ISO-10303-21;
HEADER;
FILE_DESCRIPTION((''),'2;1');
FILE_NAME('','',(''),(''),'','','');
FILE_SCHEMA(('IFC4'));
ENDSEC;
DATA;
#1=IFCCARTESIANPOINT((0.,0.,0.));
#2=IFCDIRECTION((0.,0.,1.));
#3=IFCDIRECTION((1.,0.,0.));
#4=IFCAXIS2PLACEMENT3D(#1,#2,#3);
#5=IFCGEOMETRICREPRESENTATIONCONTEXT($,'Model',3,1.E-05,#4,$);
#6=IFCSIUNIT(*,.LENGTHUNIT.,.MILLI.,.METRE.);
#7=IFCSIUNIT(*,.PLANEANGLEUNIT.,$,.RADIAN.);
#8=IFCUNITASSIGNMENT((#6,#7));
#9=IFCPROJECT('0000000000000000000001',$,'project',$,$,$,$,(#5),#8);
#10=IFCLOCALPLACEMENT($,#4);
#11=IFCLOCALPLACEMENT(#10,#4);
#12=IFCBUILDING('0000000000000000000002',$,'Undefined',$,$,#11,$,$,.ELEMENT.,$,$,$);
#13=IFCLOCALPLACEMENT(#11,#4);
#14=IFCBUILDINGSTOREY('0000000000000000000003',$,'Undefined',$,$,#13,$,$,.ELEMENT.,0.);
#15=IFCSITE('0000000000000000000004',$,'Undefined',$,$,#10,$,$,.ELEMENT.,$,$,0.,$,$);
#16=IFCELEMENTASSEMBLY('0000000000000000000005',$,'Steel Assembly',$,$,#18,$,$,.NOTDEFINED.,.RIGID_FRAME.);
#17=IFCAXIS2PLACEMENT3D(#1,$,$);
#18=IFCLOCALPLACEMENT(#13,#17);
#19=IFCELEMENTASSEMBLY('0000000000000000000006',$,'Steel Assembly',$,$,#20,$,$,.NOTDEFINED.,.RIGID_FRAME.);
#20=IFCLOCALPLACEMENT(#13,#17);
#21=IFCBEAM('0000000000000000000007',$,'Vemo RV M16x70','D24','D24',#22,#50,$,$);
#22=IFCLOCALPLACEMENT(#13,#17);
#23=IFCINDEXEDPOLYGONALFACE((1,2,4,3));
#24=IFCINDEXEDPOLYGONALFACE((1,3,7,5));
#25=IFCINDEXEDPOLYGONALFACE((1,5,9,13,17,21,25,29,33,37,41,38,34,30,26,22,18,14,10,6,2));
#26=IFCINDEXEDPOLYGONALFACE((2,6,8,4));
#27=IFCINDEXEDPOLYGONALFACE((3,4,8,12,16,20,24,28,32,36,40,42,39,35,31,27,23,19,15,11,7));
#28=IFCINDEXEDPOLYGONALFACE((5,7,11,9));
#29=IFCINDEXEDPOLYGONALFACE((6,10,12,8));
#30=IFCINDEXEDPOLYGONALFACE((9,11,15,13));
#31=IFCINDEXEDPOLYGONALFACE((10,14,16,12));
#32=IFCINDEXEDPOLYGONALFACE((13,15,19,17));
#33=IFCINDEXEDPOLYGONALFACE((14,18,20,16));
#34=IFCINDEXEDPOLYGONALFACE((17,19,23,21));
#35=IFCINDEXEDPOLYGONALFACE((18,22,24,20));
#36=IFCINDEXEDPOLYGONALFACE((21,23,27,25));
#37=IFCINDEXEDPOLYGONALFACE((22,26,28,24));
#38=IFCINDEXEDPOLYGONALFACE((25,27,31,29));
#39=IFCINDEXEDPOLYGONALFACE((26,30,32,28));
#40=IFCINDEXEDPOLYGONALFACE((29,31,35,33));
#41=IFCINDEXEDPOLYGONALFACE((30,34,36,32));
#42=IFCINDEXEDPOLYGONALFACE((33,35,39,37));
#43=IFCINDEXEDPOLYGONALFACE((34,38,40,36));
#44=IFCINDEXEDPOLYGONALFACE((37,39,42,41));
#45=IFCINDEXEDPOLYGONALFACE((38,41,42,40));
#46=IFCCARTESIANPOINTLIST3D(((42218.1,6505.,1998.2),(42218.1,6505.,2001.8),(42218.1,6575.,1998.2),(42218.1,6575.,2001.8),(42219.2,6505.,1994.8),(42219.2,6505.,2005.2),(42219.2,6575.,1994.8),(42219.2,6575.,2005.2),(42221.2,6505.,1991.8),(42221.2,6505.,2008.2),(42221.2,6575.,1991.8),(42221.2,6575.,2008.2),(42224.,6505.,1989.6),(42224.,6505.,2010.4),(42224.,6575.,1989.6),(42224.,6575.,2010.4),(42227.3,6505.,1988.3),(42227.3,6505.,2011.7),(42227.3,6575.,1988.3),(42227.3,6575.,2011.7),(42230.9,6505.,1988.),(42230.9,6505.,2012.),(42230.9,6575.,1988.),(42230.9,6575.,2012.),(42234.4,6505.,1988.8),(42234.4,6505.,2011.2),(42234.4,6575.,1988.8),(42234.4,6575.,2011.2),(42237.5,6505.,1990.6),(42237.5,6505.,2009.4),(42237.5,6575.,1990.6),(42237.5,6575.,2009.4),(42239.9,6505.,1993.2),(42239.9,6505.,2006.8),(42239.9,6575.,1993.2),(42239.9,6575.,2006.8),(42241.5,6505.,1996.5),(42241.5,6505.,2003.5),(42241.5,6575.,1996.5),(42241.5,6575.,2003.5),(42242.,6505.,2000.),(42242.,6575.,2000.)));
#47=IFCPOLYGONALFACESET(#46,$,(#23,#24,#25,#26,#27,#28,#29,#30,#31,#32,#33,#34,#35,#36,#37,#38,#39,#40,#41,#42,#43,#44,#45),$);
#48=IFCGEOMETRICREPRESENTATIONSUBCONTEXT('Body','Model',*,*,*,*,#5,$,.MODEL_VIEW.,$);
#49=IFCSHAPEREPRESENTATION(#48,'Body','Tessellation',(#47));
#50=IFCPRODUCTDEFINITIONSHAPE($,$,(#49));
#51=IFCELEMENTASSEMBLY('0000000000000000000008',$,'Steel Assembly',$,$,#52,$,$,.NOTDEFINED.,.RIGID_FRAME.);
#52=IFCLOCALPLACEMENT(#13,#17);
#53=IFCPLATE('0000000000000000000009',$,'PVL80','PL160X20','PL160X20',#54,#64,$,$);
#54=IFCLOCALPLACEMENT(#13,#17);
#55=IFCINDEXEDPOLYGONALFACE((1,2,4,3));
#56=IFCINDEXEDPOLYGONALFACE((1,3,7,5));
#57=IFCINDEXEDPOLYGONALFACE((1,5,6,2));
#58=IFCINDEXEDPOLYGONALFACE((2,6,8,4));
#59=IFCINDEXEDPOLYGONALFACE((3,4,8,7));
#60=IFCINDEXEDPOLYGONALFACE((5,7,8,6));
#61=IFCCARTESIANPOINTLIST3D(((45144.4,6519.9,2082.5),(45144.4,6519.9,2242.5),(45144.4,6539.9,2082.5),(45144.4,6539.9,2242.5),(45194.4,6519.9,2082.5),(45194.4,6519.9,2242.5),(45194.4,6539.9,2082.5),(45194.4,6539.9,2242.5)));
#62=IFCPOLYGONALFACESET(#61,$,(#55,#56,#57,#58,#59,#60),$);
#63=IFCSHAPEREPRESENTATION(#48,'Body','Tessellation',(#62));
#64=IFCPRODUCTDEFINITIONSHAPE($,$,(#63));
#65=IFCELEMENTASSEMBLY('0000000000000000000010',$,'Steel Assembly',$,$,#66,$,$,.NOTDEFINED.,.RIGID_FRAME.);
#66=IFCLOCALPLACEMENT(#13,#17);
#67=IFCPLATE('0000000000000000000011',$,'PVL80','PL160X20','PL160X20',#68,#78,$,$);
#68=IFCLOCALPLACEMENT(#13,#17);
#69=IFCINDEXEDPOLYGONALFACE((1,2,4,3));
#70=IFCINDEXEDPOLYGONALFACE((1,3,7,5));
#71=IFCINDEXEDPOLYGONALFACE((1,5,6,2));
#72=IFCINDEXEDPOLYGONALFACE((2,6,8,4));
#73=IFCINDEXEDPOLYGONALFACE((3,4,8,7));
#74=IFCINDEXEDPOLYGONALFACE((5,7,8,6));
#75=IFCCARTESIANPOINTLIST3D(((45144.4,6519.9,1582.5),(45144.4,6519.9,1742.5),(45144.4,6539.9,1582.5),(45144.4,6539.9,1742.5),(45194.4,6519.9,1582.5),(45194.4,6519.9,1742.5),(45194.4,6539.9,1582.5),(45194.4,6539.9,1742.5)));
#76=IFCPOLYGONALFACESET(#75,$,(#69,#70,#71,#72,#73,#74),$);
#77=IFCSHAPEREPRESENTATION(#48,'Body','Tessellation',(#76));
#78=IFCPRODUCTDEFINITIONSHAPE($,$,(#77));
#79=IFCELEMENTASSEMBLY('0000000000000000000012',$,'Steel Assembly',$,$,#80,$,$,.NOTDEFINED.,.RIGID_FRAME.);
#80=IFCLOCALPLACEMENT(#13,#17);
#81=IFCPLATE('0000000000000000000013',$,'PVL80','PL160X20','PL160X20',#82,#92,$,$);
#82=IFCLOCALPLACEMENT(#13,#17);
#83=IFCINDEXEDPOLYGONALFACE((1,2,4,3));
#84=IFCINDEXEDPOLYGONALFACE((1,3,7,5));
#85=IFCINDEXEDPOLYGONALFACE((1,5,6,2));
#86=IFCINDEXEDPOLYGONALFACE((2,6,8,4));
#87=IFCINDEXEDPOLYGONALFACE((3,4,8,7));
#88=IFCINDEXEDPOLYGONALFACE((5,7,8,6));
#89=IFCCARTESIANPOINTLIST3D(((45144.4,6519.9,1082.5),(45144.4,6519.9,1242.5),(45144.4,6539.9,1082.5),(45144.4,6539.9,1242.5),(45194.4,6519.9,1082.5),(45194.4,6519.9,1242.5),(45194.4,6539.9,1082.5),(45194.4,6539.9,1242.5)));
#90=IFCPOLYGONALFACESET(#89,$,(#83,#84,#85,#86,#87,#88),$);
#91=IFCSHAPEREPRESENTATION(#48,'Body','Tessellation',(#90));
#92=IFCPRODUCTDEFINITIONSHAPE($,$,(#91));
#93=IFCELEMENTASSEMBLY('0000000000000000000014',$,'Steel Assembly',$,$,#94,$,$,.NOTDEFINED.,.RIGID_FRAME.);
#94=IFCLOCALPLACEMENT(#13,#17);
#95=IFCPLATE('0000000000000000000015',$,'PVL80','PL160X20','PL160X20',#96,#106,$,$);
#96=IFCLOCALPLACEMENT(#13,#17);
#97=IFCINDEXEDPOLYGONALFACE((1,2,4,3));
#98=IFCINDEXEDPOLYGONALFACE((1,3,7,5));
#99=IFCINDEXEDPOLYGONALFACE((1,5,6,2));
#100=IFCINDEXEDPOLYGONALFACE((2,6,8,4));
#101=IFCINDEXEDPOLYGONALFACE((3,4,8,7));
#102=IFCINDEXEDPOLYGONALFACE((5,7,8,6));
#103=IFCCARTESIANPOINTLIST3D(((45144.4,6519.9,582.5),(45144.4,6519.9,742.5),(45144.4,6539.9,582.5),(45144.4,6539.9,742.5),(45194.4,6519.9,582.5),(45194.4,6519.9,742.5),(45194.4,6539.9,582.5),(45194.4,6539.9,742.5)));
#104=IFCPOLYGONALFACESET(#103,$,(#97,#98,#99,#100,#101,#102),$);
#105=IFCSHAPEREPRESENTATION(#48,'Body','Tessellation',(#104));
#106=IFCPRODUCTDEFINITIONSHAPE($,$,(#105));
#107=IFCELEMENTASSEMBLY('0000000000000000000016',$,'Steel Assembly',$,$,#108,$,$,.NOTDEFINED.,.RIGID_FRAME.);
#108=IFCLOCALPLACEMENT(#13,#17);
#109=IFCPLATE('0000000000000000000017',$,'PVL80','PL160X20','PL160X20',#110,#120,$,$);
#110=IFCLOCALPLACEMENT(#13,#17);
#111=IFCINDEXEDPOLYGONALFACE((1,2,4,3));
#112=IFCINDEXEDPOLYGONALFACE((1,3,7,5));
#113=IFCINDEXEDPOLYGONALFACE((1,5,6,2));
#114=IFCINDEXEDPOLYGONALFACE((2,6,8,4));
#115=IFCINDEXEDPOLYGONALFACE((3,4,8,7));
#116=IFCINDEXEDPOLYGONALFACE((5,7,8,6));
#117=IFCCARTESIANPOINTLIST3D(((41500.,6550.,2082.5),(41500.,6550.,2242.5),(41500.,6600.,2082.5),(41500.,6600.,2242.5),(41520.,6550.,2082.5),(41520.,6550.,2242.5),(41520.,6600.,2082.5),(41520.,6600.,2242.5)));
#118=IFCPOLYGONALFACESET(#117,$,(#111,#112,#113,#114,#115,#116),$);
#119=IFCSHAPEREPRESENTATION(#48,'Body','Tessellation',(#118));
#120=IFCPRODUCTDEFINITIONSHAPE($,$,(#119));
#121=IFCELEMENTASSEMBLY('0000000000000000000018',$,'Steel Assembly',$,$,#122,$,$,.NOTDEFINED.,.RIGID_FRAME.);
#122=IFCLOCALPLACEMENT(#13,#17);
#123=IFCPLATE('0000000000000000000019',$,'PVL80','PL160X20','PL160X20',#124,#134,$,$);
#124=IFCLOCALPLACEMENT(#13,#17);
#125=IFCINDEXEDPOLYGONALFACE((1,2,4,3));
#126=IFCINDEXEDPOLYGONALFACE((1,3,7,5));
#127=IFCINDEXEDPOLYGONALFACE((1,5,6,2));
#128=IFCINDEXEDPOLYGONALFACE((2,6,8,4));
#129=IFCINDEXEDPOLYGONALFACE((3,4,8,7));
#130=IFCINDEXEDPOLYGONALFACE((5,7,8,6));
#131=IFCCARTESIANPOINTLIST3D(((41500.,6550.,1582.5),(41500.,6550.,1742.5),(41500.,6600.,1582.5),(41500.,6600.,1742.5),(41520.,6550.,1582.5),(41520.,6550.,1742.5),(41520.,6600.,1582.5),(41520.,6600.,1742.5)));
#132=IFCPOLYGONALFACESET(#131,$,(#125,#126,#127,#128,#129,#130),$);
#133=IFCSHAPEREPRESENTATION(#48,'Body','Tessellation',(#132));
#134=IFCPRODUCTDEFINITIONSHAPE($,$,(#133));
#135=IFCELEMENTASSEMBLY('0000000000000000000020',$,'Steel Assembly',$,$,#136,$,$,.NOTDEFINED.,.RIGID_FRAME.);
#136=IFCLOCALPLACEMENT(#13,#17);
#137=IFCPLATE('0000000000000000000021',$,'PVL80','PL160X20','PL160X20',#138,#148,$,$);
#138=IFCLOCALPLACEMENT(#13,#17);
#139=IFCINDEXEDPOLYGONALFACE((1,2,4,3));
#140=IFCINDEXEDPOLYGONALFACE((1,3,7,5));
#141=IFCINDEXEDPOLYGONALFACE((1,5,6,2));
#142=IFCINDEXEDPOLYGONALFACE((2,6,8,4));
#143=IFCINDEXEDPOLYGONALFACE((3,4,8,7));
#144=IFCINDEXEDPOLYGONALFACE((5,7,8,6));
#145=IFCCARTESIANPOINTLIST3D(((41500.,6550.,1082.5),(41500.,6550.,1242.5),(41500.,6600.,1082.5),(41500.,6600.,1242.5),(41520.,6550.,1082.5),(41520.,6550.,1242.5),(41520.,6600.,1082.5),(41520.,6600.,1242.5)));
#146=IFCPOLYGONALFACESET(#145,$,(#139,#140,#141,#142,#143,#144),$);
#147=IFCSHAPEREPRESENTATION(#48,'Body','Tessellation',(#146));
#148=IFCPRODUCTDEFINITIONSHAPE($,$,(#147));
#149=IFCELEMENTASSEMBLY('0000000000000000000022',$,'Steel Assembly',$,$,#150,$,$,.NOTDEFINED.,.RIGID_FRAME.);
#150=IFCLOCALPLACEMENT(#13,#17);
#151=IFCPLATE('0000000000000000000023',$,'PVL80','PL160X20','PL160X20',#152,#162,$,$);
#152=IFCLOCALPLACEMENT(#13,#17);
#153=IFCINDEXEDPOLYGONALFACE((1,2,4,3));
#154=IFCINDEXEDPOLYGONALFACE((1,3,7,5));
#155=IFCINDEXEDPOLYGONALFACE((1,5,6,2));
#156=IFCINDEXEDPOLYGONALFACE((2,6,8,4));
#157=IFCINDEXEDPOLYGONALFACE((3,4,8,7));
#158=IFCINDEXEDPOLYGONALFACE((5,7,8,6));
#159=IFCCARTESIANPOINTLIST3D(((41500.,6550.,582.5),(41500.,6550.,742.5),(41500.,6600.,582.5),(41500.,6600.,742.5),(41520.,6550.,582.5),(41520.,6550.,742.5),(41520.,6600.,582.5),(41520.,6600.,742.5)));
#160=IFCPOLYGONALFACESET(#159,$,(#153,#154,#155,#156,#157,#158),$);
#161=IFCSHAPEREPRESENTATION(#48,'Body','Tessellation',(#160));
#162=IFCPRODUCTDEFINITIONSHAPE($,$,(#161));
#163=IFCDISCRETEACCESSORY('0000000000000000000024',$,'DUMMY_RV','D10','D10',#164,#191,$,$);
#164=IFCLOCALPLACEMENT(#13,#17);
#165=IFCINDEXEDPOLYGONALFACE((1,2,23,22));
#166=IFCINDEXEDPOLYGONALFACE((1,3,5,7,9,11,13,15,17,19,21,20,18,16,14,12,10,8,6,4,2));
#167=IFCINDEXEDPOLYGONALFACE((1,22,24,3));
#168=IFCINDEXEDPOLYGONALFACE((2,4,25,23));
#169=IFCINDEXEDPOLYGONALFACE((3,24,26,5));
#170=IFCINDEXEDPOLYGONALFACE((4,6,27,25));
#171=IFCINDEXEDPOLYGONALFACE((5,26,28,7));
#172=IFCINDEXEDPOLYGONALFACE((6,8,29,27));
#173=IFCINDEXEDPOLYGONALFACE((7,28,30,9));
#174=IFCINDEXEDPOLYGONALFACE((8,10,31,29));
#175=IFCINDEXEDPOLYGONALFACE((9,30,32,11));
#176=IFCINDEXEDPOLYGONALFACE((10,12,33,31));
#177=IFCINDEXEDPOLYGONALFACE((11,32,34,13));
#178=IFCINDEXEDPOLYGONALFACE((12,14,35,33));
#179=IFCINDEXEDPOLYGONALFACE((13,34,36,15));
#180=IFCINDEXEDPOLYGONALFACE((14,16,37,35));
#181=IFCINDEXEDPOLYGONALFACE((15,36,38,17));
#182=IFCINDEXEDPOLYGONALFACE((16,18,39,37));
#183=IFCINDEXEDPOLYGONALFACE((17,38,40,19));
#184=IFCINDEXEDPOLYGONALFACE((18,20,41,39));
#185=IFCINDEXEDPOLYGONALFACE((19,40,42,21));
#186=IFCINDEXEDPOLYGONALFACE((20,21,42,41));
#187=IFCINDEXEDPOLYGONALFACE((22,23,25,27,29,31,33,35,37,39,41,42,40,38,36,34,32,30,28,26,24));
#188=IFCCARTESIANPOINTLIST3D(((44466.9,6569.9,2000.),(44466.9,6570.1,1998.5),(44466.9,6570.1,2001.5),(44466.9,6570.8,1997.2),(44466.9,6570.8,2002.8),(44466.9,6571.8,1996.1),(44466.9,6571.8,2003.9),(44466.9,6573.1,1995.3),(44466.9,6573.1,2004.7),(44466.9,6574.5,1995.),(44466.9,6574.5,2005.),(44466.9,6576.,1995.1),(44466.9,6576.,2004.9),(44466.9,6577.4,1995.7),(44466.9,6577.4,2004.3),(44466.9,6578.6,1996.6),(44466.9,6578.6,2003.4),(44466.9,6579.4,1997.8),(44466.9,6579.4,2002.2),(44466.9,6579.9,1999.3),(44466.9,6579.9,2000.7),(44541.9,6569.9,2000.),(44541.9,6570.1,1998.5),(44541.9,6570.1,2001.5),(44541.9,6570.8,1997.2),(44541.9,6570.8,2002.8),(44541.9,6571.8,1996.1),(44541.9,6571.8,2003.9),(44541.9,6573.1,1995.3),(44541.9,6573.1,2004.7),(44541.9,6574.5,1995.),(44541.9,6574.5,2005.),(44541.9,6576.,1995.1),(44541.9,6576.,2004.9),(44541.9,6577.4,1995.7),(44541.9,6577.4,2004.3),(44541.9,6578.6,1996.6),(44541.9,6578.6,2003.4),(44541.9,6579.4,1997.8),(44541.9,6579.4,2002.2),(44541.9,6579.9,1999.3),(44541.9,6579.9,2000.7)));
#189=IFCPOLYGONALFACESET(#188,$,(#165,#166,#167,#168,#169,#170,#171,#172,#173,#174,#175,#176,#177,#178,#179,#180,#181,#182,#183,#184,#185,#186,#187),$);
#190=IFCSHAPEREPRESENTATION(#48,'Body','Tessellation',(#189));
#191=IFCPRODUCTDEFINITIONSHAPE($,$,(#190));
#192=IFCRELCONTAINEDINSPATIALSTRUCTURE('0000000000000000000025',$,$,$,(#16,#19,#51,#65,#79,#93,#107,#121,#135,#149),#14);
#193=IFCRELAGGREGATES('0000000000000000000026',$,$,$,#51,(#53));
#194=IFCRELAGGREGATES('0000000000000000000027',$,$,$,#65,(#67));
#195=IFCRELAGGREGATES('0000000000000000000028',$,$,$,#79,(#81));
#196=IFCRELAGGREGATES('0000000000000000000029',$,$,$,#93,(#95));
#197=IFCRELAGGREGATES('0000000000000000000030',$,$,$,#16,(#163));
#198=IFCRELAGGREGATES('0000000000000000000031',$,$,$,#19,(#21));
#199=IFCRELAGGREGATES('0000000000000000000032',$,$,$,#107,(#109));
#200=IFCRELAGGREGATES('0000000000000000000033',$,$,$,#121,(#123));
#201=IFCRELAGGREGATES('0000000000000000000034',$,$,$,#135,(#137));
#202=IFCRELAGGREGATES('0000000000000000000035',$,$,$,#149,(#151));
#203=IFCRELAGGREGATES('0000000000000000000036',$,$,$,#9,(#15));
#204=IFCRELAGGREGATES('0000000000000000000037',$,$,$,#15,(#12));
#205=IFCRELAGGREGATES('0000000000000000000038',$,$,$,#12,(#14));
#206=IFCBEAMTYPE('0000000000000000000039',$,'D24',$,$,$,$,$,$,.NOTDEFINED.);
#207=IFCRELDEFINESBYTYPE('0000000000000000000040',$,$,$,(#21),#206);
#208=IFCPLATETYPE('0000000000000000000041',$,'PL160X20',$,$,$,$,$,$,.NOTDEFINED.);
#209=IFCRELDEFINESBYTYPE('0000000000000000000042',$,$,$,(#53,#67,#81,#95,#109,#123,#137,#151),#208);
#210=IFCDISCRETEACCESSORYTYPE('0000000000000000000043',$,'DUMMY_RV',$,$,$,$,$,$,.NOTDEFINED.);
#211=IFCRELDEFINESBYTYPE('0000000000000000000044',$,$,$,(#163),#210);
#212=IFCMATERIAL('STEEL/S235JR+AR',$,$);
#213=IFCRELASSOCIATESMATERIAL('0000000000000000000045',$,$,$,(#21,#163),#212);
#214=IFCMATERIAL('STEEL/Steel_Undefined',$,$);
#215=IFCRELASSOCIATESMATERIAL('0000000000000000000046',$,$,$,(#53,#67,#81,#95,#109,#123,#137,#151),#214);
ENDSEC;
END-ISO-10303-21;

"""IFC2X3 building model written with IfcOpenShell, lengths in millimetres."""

from ifc_helpers import new_model, si_unit, frame, origin_with_axes, origin_2d_with_axis, place, context, subcontext, project, spatial, polyline, circle, outline, extrude, material, type_object, element, aggregate, save


model = new_model("IFC2X3")

# Units and contexts
model_context = context("Model", 3, precision=1e-05, world=origin_with_axes())
body_context = subcontext(model_context, "Body", "Model", "MODEL_VIEW")
ifc_project = project(units=[si_unit("LENGTHUNIT", "METRE", prefix="MILLI"), si_unit("PLANEANGLEUNIT", "RADIAN")], contexts=[model_context])

# Site, building, storey
site_placement = place(None, origin_with_axes())
site = spatial("IfcSite", under=ifc_project, at=site_placement, Name="Undefined", CompositionType="ELEMENT", RefElevation=0.0)
building_placement = place(site_placement, origin_with_axes())
building = spatial("IfcBuilding", under=site, at=building_placement, Name="Undefined", CompositionType="ELEMENT")
storey_placement = place(building_placement, origin_with_axes())
storey = spatial("IfcBuildingStorey", under=building, at=storey_placement, Name="Undefined", CompositionType="ELEMENT", Elevation=0.0)

# Element assemblies, beam
assembly_1_placement = place(storey_placement, origin_with_axes())
assembly_1 = element("IfcElementAssembly", 1, at=assembly_1_placement, inside=storey, Name="Steel Assembly", AssemblyPlace="NOTDEFINED", PredefinedType="RIGID_FRAME")
ifc_material_1 = material(Name="STEEL/S235JR+AR")
beam_type_1 = type_object("IfcBeamType", Name="D24", PredefinedType="NOTDEFINED")
assembly_2_placement = place(storey_placement, origin_with_axes())
assembly_2 = element("IfcElementAssembly", 2, at=assembly_2_placement, inside=storey, Name="Steel Assembly", AssemblyPlace="NOTDEFINED", PredefinedType="RIGID_FRAME")
beam_1_placement = place(assembly_2_placement, frame((42230.0, 6505.0, 2000.0), z_axis=(0.0, 0.0, 1.0), x_axis=(0.00003, 1.0, 0.0)))
beam_1 = element("IfcBeam", 3, at=beam_1_placement, type_object=beam_type_1, material=ifc_material_1, Name="Vemo RV M16x70", Description="D24", ObjectType="D24", context=body_context, shape_type="SweptSolid", body=[
    extrude(circle(Radius=12.0, at=origin_2d_with_axis()), frame((70.0, 0.0, 0.0), z_axis=(-1.0, 0.0, 0.0), x_axis=(0.0, -1.0, 0.0)), (0.0, 0.0, 1.0), 70.0),
])

# Element assemblies, plates
assembly_3_placement = place(storey_placement, origin_with_axes())
assembly_3 = element("IfcElementAssembly", 4, at=assembly_3_placement, inside=storey, Name="Steel Assembly", AssemblyPlace="NOTDEFINED", PredefinedType="RIGID_FRAME")
ifc_material_2 = material(Name="STEEL/Steel_Undefined")
plate_type = type_object("IfcPlateType", Name="PL160X20", PredefinedType="NOTDEFINED")
plate_1_placement = place(assembly_3_placement, frame((45194.4, 6519.9, 2162.5), z_axis=(0.0, 0.0, -1.0), x_axis=(-1.0, 0.00003, 0.0)))
plate_1 = element("IfcPlate", 5, at=plate_1_placement, type_object=plate_type, material=ifc_material_2, Name="PVL80", Description="PL160X20", ObjectType="PL160X20", context=body_context, shape_type="SweptSolid", body=[
    extrude(outline(polyline([(0.0, 0.0), (50.0, 0.0), (50.0, 20.0), (0.0, 20.0), (0.0, 0.0)])), frame((0.0, 0.0, -80.0), z_axis=(0.0, 0.0, 1.0), x_axis=(1.0, 0.0, 0.0)), (0.0, 0.0, 1.0), 160.0),
])
assembly_4_placement = place(storey_placement, origin_with_axes())
assembly_4 = element("IfcElementAssembly", 6, at=assembly_4_placement, inside=storey, Name="Steel Assembly", AssemblyPlace="NOTDEFINED", PredefinedType="RIGID_FRAME")
plate_2_placement = place(assembly_4_placement, frame((45194.4, 6519.9, 1662.5), z_axis=(0.0, 0.0, -1.0), x_axis=(-1.0, 0.00003, 0.0)))
plate_2 = element("IfcPlate", 7, at=plate_2_placement, type_object=plate_type, material=ifc_material_2, Name="PVL80", Description="PL160X20", ObjectType="PL160X20", context=body_context, shape_type="SweptSolid", body=[
    extrude(outline(polyline([(0.0, 0.0), (50.0, 0.0), (50.0, 20.0), (0.0, 20.0), (0.0, 0.0)])), frame((0.0, 0.0, -80.0), z_axis=(0.0, 0.0, 1.0), x_axis=(1.0, 0.0, 0.0)), (0.0, 0.0, 1.0), 160.0),
])
assembly_5_placement = place(storey_placement, origin_with_axes())
assembly_5 = element("IfcElementAssembly", 8, at=assembly_5_placement, inside=storey, Name="Steel Assembly", AssemblyPlace="NOTDEFINED", PredefinedType="RIGID_FRAME")
plate_3_placement = place(assembly_5_placement, frame((45194.4, 6519.9, 1162.5), z_axis=(0.0, 0.0, -1.0), x_axis=(-1.0, 0.00003, 0.0)))
plate_3 = element("IfcPlate", 9, at=plate_3_placement, type_object=plate_type, material=ifc_material_2, Name="PVL80", Description="PL160X20", ObjectType="PL160X20", context=body_context, shape_type="SweptSolid", body=[
    extrude(outline(polyline([(0.0, 0.0), (50.0, 0.0), (50.0, 20.0), (0.0, 20.0), (0.0, 0.0)])), frame((0.0, 0.0, -80.0), z_axis=(0.0, 0.0, 1.0), x_axis=(1.0, 0.0, 0.0)), (0.0, 0.0, 1.0), 160.0),
])
assembly_6_placement = place(storey_placement, origin_with_axes())
assembly_6 = element("IfcElementAssembly", 10, at=assembly_6_placement, inside=storey, Name="Steel Assembly", AssemblyPlace="NOTDEFINED", PredefinedType="RIGID_FRAME")
plate_4_placement = place(assembly_6_placement, frame((45194.4, 6519.9, 662.5), z_axis=(0.0, 0.0, -1.0), x_axis=(-1.0, 0.00003, 0.0)))
plate_4 = element("IfcPlate", 11, at=plate_4_placement, type_object=plate_type, material=ifc_material_2, Name="PVL80", Description="PL160X20", ObjectType="PL160X20", context=body_context, shape_type="SweptSolid", body=[
    extrude(outline(polyline([(0.0, 0.0), (50.0, 0.0), (50.0, 20.0), (0.0, 20.0), (0.0, 0.0)])), frame((0.0, 0.0, -80.0), z_axis=(0.0, 0.0, 1.0), x_axis=(1.0, 0.0, 0.0)), (0.0, 0.0, 1.0), 160.0),
])
assembly_7_placement = place(storey_placement, origin_with_axes())
assembly_7 = element("IfcElementAssembly", 12, at=assembly_7_placement, inside=storey, Name="Steel Assembly", AssemblyPlace="NOTDEFINED", PredefinedType="RIGID_FRAME")
plate_5_placement = place(assembly_7_placement, frame((41500.0, 6550.0, 2162.5), z_axis=(0.0, 0.0, -1.0), x_axis=(0.00003, 1.0, 0.0)))
plate_5 = element("IfcPlate", 13, at=plate_5_placement, type_object=plate_type, material=ifc_material_2, Name="PVL80", Description="PL160X20", ObjectType="PL160X20", context=body_context, shape_type="SweptSolid", body=[
    extrude(outline(polyline([(0.0, 0.0), (50.0, 0.0), (50.0, 20.0), (0.0, 20.0), (0.0, 0.0)])), frame((0.0, 0.0, -80.0), z_axis=(0.0, 0.0, 1.0), x_axis=(1.0, 0.0, 0.0)), (0.0, 0.0, 1.0), 160.0),
])
assembly_8_placement = place(storey_placement, origin_with_axes())
assembly_8 = element("IfcElementAssembly", 14, at=assembly_8_placement, inside=storey, Name="Steel Assembly", AssemblyPlace="NOTDEFINED", PredefinedType="RIGID_FRAME")
plate_6_placement = place(assembly_8_placement, frame((41500.0, 6550.0, 1662.5), z_axis=(0.0, 0.0, -1.0), x_axis=(0.00003, 1.0, 0.0)))
plate_6 = element("IfcPlate", 15, at=plate_6_placement, type_object=plate_type, material=ifc_material_2, Name="PVL80", Description="PL160X20", ObjectType="PL160X20", context=body_context, shape_type="SweptSolid", body=[
    extrude(outline(polyline([(0.0, 0.0), (50.0, 0.0), (50.0, 20.0), (0.0, 20.0), (0.0, 0.0)])), frame((0.0, 0.0, -80.0), z_axis=(0.0, 0.0, 1.0), x_axis=(1.0, 0.0, 0.0)), (0.0, 0.0, 1.0), 160.0),
])
assembly_9_placement = place(storey_placement, origin_with_axes())
assembly_9 = element("IfcElementAssembly", 16, at=assembly_9_placement, inside=storey, Name="Steel Assembly", AssemblyPlace="NOTDEFINED", PredefinedType="RIGID_FRAME")
plate_7_placement = place(assembly_9_placement, frame((41500.0, 6550.0, 1162.5), z_axis=(0.0, 0.0, -1.0), x_axis=(0.00003, 1.0, 0.0)))
plate_7 = element("IfcPlate", 17, at=plate_7_placement, type_object=plate_type, material=ifc_material_2, Name="PVL80", Description="PL160X20", ObjectType="PL160X20", context=body_context, shape_type="SweptSolid", body=[
    extrude(outline(polyline([(0.0, 0.0), (50.0, 0.0), (50.0, 20.0), (0.0, 20.0), (0.0, 0.0)])), frame((0.0, 0.0, -80.0), z_axis=(0.0, 0.0, 1.0), x_axis=(1.0, 0.0, 0.0)), (0.0, 0.0, 1.0), 160.0),
])
assembly_10_placement = place(storey_placement, origin_with_axes())
assembly_10 = element("IfcElementAssembly", 18, at=assembly_10_placement, inside=storey, Name="Steel Assembly", AssemblyPlace="NOTDEFINED", PredefinedType="RIGID_FRAME")
plate_8_placement = place(assembly_10_placement, frame((41500.0, 6550.0, 662.5), z_axis=(0.0, 0.0, -1.0), x_axis=(0.00003, 1.0, 0.0)))
plate_8 = element("IfcPlate", 19, at=plate_8_placement, type_object=plate_type, material=ifc_material_2, Name="PVL80", Description="PL160X20", ObjectType="PL160X20", context=body_context, shape_type="SweptSolid", body=[
    extrude(outline(polyline([(0.0, 0.0), (50.0, 0.0), (50.0, 20.0), (0.0, 20.0), (0.0, 0.0)])), frame((0.0, 0.0, -80.0), z_axis=(0.0, 0.0, 1.0), x_axis=(1.0, 0.0, 0.0)), (0.0, 0.0, 1.0), 160.0),
])

aggregate(assembly_3, [plate_1])
aggregate(assembly_4, [plate_2])
aggregate(assembly_5, [plate_3])
aggregate(assembly_6, [plate_4])

# Discrete accessory
discrete_accessory_type = type_object("IfcDiscreteAccessoryType", Name="DUMMY_RV")
discrete_accessory_1_placement = place(assembly_1_placement, frame((44466.9, 6574.9, 2000.0), z_axis=(0.0, 0.0, 1.0), x_axis=(1.0, -0.00003, 0.0)))
discrete_accessory_1 = element("IfcDiscreteAccessory", 20, at=discrete_accessory_1_placement, type_object=discrete_accessory_type, material=ifc_material_1, Name="DUMMY_RV", Description="D10", ObjectType="D10", context=body_context, shape_type="SweptSolid", body=[
    extrude(circle(Radius=5.0, at=origin_2d_with_axis()), frame((75.0, 0.0, 0.0), z_axis=(-1.0, 0.0, 0.0), x_axis=(0.0, -1.0, 0.0)), (0.0, 0.0, 1.0), 75.0),
])
aggregate(assembly_1, [discrete_accessory_1])
aggregate(assembly_2, [beam_1])

aggregate(assembly_7, [plate_5])
aggregate(assembly_8, [plate_6])
aggregate(assembly_9, [plate_7])
aggregate(assembly_10, [plate_8])

save(model, "model.ifc")
